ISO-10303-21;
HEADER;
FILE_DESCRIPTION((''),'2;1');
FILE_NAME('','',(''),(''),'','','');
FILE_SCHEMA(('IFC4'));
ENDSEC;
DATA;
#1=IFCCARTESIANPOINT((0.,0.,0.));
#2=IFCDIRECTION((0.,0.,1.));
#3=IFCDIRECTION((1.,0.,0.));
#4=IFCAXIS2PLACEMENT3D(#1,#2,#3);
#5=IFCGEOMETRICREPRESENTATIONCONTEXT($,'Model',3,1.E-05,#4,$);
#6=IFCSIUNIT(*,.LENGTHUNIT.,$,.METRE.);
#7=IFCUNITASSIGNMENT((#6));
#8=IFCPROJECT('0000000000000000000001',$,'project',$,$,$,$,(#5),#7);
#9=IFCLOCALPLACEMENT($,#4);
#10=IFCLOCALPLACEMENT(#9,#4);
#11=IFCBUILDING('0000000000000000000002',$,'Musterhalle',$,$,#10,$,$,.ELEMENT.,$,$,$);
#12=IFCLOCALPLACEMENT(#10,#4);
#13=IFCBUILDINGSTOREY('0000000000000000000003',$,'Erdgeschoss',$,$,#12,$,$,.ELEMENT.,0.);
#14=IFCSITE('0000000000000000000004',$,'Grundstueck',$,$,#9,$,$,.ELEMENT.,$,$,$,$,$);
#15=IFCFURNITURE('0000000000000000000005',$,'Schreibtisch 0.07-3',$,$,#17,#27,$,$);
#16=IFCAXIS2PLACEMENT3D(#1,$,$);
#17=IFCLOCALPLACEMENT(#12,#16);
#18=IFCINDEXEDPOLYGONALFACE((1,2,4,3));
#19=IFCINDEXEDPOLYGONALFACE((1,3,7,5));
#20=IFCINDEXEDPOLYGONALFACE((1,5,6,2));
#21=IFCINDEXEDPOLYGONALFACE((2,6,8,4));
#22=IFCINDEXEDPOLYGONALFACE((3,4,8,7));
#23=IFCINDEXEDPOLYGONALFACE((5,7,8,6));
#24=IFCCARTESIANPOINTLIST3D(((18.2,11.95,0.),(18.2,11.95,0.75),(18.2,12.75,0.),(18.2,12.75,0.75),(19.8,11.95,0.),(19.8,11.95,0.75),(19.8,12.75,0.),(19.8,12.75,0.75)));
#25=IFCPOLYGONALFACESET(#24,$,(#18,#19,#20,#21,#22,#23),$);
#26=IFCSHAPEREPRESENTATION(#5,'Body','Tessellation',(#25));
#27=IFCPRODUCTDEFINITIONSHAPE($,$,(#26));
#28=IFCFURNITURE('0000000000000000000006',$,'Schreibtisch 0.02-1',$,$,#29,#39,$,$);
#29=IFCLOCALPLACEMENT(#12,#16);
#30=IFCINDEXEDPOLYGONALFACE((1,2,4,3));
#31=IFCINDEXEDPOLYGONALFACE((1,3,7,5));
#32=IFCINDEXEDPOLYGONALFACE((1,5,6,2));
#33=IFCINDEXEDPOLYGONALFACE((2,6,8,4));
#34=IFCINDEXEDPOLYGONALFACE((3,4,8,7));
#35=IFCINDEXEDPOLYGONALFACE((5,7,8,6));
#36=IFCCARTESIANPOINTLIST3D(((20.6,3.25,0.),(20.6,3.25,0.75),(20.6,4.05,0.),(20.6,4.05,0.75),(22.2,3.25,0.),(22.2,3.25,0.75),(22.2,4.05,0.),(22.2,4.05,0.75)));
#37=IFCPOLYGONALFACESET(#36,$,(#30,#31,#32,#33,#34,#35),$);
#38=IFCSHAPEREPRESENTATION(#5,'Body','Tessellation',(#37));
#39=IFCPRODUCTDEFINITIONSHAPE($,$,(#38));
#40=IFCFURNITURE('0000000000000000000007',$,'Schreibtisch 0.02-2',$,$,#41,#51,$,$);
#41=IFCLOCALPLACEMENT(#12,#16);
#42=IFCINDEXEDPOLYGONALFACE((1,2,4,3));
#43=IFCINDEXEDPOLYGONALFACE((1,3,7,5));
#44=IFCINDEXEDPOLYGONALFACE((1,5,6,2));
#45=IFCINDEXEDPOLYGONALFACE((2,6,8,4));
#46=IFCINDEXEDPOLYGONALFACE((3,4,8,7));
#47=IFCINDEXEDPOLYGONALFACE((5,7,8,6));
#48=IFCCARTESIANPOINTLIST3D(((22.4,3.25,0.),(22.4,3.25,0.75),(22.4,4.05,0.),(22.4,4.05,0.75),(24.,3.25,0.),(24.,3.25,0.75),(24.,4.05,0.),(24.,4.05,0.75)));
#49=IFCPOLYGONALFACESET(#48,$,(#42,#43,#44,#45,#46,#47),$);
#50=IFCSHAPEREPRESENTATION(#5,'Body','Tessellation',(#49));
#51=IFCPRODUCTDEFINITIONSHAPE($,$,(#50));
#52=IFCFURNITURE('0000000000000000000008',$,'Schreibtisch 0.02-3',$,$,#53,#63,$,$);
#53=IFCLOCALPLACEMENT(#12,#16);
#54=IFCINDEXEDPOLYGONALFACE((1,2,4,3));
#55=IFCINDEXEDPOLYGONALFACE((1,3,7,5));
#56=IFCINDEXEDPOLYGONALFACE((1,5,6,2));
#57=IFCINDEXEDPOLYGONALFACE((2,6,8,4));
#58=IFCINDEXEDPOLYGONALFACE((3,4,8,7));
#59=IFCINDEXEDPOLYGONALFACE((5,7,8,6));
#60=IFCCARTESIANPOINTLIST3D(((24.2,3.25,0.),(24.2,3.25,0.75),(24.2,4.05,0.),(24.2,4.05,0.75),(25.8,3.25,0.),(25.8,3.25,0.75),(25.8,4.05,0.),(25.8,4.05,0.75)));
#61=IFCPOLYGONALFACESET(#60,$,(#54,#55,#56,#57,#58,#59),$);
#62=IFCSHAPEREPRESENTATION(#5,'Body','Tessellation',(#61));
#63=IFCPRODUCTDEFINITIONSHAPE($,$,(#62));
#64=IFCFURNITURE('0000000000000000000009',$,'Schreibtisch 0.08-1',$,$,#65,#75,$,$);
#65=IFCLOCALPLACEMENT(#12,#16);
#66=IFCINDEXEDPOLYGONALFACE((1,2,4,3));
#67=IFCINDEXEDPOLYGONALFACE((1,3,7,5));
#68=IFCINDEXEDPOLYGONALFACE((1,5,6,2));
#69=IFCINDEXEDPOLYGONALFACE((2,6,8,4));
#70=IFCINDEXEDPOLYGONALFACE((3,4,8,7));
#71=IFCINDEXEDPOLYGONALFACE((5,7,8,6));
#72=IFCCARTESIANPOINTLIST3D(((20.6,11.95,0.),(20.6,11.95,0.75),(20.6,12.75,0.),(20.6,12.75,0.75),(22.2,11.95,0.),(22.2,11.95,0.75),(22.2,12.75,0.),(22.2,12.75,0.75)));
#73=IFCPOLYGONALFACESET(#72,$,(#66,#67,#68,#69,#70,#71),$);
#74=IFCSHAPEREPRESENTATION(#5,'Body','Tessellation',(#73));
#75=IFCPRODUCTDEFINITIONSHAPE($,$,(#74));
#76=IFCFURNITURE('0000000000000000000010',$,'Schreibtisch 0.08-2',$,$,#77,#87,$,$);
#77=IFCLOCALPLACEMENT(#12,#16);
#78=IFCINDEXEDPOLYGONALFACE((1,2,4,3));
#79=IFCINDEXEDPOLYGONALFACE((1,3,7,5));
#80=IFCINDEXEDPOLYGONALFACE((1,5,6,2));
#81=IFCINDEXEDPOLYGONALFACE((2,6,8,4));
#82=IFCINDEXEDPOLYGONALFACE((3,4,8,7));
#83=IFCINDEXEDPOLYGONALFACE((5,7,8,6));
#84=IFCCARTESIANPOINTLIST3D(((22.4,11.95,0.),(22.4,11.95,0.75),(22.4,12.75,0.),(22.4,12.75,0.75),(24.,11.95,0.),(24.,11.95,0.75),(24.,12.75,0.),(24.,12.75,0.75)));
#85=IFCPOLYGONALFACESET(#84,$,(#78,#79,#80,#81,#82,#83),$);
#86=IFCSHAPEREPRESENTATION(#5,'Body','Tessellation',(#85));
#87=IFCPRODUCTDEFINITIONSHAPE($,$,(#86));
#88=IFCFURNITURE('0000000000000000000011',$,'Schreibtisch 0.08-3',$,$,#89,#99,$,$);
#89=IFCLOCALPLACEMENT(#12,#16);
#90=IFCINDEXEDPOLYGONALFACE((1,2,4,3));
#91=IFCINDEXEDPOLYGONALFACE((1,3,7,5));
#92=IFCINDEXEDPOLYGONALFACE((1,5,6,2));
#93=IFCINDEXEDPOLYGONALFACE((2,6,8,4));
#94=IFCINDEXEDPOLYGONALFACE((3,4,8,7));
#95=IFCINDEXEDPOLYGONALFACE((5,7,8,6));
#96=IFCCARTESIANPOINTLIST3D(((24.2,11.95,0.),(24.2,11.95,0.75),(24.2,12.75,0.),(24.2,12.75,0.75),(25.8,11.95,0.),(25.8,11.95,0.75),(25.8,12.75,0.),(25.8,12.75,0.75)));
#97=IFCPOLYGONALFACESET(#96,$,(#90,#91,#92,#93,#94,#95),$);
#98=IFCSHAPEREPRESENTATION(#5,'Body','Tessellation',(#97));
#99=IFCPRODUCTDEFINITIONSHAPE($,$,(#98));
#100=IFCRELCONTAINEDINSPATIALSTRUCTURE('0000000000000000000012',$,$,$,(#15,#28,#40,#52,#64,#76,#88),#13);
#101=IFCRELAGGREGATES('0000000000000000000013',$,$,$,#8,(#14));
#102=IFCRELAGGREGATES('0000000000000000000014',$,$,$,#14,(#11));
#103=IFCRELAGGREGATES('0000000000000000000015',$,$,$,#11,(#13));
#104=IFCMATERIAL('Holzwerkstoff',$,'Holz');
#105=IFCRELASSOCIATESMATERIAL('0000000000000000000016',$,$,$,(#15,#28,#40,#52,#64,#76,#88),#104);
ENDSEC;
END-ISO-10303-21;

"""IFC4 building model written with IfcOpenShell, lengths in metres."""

from ifc_helpers import new_model, si_unit, frame, origin_with_axes, origin_2d, place, context, project, spatial, rectangle, extrude, material, element, save


model = new_model("IFC4")

# Units and contexts
model_context = context("Model", 3, precision=1e-05, world=origin_with_axes())
ifc_project = project(units=[si_unit("LENGTHUNIT", "METRE")], contexts=[model_context])

# Site, building, storey
site_placement = place(None, origin_with_axes())
site = spatial("IfcSite", under=ifc_project, at=site_placement, Name="Grundstueck", CompositionType="ELEMENT")
building_placement = place(site_placement, origin_with_axes())
building = spatial("IfcBuilding", under=site, at=building_placement, Name="Musterhalle", CompositionType="ELEMENT")
storey_placement = place(building_placement, origin_with_axes())
storey = spatial("IfcBuildingStorey", under=building, at=storey_placement, Name="Erdgeschoss", CompositionType="ELEMENT", Elevation=0.0)

# Shared definitions
placement = place(storey_placement, origin_with_axes())

# Shared definitions
ifc_material_1 = material(Name="Holzwerkstoff", Category="Holz")

# Furniture
element("IfcFurniture", 1, at=placement, inside=storey, material=ifc_material_1, Name="Schreibtisch 0.07-3", context=model_context, shape_type="SweptSolid", body=[
    extrude(rectangle(XDim=1.6, YDim=0.8, at=origin_2d()), frame((19.0, 12.35, 0.0), z_axis=(0.0, 0.0, 1.0), x_axis=(1.0, 0.0, 0.0)), (0.0, 0.0, 1.0), 0.75),
])
element("IfcFurniture", 2, at=placement, inside=storey, material=ifc_material_1, Name="Schreibtisch 0.02-1", context=model_context, shape_type="SweptSolid", body=[
    extrude(rectangle(XDim=1.6, YDim=0.8, at=origin_2d()), frame((21.4, 3.65, 0.0), z_axis=(0.0, 0.0, 1.0), x_axis=(1.0, 0.0, 0.0)), (0.0, 0.0, 1.0), 0.75),
])
element("IfcFurniture", 3, at=placement, inside=storey, material=ifc_material_1, Name="Schreibtisch 0.02-2", context=model_context, shape_type="SweptSolid", body=[
    extrude(rectangle(XDim=1.6, YDim=0.8, at=origin_2d()), frame((23.2, 3.65, 0.0), z_axis=(0.0, 0.0, 1.0), x_axis=(1.0, 0.0, 0.0)), (0.0, 0.0, 1.0), 0.75),
])
element("IfcFurniture", 4, at=placement, inside=storey, material=ifc_material_1, Name="Schreibtisch 0.02-3", context=model_context, shape_type="SweptSolid", body=[
    extrude(rectangle(XDim=1.6, YDim=0.8, at=origin_2d()), frame((25.0, 3.65, 0.0), z_axis=(0.0, 0.0, 1.0), x_axis=(1.0, 0.0, 0.0)), (0.0, 0.0, 1.0), 0.75),
])
element("IfcFurniture", 5, at=placement, inside=storey, material=ifc_material_1, Name="Schreibtisch 0.08-1", context=model_context, shape_type="SweptSolid", body=[
    extrude(rectangle(XDim=1.6, YDim=0.8, at=origin_2d()), frame((21.4, 12.35, 0.0), z_axis=(0.0, 0.0, 1.0), x_axis=(1.0, 0.0, 0.0)), (0.0, 0.0, 1.0), 0.75),
])
element("IfcFurniture", 6, at=placement, inside=storey, material=ifc_material_1, Name="Schreibtisch 0.08-2", context=model_context, shape_type="SweptSolid", body=[
    extrude(rectangle(XDim=1.6, YDim=0.8, at=origin_2d()), frame((23.2, 12.35, 0.0), z_axis=(0.0, 0.0, 1.0), x_axis=(1.0, 0.0, 0.0)), (0.0, 0.0, 1.0), 0.75),
])
element("IfcFurniture", 7, at=placement, inside=storey, material=ifc_material_1, Name="Schreibtisch 0.08-3", context=model_context, shape_type="SweptSolid", body=[
    extrude(rectangle(XDim=1.6, YDim=0.8, at=origin_2d()), frame((25.0, 12.35, 0.0), z_axis=(0.0, 0.0, 1.0), x_axis=(1.0, 0.0, 0.0)), (0.0, 0.0, 1.0), 0.75),
])

save(model, "model.ifc")
